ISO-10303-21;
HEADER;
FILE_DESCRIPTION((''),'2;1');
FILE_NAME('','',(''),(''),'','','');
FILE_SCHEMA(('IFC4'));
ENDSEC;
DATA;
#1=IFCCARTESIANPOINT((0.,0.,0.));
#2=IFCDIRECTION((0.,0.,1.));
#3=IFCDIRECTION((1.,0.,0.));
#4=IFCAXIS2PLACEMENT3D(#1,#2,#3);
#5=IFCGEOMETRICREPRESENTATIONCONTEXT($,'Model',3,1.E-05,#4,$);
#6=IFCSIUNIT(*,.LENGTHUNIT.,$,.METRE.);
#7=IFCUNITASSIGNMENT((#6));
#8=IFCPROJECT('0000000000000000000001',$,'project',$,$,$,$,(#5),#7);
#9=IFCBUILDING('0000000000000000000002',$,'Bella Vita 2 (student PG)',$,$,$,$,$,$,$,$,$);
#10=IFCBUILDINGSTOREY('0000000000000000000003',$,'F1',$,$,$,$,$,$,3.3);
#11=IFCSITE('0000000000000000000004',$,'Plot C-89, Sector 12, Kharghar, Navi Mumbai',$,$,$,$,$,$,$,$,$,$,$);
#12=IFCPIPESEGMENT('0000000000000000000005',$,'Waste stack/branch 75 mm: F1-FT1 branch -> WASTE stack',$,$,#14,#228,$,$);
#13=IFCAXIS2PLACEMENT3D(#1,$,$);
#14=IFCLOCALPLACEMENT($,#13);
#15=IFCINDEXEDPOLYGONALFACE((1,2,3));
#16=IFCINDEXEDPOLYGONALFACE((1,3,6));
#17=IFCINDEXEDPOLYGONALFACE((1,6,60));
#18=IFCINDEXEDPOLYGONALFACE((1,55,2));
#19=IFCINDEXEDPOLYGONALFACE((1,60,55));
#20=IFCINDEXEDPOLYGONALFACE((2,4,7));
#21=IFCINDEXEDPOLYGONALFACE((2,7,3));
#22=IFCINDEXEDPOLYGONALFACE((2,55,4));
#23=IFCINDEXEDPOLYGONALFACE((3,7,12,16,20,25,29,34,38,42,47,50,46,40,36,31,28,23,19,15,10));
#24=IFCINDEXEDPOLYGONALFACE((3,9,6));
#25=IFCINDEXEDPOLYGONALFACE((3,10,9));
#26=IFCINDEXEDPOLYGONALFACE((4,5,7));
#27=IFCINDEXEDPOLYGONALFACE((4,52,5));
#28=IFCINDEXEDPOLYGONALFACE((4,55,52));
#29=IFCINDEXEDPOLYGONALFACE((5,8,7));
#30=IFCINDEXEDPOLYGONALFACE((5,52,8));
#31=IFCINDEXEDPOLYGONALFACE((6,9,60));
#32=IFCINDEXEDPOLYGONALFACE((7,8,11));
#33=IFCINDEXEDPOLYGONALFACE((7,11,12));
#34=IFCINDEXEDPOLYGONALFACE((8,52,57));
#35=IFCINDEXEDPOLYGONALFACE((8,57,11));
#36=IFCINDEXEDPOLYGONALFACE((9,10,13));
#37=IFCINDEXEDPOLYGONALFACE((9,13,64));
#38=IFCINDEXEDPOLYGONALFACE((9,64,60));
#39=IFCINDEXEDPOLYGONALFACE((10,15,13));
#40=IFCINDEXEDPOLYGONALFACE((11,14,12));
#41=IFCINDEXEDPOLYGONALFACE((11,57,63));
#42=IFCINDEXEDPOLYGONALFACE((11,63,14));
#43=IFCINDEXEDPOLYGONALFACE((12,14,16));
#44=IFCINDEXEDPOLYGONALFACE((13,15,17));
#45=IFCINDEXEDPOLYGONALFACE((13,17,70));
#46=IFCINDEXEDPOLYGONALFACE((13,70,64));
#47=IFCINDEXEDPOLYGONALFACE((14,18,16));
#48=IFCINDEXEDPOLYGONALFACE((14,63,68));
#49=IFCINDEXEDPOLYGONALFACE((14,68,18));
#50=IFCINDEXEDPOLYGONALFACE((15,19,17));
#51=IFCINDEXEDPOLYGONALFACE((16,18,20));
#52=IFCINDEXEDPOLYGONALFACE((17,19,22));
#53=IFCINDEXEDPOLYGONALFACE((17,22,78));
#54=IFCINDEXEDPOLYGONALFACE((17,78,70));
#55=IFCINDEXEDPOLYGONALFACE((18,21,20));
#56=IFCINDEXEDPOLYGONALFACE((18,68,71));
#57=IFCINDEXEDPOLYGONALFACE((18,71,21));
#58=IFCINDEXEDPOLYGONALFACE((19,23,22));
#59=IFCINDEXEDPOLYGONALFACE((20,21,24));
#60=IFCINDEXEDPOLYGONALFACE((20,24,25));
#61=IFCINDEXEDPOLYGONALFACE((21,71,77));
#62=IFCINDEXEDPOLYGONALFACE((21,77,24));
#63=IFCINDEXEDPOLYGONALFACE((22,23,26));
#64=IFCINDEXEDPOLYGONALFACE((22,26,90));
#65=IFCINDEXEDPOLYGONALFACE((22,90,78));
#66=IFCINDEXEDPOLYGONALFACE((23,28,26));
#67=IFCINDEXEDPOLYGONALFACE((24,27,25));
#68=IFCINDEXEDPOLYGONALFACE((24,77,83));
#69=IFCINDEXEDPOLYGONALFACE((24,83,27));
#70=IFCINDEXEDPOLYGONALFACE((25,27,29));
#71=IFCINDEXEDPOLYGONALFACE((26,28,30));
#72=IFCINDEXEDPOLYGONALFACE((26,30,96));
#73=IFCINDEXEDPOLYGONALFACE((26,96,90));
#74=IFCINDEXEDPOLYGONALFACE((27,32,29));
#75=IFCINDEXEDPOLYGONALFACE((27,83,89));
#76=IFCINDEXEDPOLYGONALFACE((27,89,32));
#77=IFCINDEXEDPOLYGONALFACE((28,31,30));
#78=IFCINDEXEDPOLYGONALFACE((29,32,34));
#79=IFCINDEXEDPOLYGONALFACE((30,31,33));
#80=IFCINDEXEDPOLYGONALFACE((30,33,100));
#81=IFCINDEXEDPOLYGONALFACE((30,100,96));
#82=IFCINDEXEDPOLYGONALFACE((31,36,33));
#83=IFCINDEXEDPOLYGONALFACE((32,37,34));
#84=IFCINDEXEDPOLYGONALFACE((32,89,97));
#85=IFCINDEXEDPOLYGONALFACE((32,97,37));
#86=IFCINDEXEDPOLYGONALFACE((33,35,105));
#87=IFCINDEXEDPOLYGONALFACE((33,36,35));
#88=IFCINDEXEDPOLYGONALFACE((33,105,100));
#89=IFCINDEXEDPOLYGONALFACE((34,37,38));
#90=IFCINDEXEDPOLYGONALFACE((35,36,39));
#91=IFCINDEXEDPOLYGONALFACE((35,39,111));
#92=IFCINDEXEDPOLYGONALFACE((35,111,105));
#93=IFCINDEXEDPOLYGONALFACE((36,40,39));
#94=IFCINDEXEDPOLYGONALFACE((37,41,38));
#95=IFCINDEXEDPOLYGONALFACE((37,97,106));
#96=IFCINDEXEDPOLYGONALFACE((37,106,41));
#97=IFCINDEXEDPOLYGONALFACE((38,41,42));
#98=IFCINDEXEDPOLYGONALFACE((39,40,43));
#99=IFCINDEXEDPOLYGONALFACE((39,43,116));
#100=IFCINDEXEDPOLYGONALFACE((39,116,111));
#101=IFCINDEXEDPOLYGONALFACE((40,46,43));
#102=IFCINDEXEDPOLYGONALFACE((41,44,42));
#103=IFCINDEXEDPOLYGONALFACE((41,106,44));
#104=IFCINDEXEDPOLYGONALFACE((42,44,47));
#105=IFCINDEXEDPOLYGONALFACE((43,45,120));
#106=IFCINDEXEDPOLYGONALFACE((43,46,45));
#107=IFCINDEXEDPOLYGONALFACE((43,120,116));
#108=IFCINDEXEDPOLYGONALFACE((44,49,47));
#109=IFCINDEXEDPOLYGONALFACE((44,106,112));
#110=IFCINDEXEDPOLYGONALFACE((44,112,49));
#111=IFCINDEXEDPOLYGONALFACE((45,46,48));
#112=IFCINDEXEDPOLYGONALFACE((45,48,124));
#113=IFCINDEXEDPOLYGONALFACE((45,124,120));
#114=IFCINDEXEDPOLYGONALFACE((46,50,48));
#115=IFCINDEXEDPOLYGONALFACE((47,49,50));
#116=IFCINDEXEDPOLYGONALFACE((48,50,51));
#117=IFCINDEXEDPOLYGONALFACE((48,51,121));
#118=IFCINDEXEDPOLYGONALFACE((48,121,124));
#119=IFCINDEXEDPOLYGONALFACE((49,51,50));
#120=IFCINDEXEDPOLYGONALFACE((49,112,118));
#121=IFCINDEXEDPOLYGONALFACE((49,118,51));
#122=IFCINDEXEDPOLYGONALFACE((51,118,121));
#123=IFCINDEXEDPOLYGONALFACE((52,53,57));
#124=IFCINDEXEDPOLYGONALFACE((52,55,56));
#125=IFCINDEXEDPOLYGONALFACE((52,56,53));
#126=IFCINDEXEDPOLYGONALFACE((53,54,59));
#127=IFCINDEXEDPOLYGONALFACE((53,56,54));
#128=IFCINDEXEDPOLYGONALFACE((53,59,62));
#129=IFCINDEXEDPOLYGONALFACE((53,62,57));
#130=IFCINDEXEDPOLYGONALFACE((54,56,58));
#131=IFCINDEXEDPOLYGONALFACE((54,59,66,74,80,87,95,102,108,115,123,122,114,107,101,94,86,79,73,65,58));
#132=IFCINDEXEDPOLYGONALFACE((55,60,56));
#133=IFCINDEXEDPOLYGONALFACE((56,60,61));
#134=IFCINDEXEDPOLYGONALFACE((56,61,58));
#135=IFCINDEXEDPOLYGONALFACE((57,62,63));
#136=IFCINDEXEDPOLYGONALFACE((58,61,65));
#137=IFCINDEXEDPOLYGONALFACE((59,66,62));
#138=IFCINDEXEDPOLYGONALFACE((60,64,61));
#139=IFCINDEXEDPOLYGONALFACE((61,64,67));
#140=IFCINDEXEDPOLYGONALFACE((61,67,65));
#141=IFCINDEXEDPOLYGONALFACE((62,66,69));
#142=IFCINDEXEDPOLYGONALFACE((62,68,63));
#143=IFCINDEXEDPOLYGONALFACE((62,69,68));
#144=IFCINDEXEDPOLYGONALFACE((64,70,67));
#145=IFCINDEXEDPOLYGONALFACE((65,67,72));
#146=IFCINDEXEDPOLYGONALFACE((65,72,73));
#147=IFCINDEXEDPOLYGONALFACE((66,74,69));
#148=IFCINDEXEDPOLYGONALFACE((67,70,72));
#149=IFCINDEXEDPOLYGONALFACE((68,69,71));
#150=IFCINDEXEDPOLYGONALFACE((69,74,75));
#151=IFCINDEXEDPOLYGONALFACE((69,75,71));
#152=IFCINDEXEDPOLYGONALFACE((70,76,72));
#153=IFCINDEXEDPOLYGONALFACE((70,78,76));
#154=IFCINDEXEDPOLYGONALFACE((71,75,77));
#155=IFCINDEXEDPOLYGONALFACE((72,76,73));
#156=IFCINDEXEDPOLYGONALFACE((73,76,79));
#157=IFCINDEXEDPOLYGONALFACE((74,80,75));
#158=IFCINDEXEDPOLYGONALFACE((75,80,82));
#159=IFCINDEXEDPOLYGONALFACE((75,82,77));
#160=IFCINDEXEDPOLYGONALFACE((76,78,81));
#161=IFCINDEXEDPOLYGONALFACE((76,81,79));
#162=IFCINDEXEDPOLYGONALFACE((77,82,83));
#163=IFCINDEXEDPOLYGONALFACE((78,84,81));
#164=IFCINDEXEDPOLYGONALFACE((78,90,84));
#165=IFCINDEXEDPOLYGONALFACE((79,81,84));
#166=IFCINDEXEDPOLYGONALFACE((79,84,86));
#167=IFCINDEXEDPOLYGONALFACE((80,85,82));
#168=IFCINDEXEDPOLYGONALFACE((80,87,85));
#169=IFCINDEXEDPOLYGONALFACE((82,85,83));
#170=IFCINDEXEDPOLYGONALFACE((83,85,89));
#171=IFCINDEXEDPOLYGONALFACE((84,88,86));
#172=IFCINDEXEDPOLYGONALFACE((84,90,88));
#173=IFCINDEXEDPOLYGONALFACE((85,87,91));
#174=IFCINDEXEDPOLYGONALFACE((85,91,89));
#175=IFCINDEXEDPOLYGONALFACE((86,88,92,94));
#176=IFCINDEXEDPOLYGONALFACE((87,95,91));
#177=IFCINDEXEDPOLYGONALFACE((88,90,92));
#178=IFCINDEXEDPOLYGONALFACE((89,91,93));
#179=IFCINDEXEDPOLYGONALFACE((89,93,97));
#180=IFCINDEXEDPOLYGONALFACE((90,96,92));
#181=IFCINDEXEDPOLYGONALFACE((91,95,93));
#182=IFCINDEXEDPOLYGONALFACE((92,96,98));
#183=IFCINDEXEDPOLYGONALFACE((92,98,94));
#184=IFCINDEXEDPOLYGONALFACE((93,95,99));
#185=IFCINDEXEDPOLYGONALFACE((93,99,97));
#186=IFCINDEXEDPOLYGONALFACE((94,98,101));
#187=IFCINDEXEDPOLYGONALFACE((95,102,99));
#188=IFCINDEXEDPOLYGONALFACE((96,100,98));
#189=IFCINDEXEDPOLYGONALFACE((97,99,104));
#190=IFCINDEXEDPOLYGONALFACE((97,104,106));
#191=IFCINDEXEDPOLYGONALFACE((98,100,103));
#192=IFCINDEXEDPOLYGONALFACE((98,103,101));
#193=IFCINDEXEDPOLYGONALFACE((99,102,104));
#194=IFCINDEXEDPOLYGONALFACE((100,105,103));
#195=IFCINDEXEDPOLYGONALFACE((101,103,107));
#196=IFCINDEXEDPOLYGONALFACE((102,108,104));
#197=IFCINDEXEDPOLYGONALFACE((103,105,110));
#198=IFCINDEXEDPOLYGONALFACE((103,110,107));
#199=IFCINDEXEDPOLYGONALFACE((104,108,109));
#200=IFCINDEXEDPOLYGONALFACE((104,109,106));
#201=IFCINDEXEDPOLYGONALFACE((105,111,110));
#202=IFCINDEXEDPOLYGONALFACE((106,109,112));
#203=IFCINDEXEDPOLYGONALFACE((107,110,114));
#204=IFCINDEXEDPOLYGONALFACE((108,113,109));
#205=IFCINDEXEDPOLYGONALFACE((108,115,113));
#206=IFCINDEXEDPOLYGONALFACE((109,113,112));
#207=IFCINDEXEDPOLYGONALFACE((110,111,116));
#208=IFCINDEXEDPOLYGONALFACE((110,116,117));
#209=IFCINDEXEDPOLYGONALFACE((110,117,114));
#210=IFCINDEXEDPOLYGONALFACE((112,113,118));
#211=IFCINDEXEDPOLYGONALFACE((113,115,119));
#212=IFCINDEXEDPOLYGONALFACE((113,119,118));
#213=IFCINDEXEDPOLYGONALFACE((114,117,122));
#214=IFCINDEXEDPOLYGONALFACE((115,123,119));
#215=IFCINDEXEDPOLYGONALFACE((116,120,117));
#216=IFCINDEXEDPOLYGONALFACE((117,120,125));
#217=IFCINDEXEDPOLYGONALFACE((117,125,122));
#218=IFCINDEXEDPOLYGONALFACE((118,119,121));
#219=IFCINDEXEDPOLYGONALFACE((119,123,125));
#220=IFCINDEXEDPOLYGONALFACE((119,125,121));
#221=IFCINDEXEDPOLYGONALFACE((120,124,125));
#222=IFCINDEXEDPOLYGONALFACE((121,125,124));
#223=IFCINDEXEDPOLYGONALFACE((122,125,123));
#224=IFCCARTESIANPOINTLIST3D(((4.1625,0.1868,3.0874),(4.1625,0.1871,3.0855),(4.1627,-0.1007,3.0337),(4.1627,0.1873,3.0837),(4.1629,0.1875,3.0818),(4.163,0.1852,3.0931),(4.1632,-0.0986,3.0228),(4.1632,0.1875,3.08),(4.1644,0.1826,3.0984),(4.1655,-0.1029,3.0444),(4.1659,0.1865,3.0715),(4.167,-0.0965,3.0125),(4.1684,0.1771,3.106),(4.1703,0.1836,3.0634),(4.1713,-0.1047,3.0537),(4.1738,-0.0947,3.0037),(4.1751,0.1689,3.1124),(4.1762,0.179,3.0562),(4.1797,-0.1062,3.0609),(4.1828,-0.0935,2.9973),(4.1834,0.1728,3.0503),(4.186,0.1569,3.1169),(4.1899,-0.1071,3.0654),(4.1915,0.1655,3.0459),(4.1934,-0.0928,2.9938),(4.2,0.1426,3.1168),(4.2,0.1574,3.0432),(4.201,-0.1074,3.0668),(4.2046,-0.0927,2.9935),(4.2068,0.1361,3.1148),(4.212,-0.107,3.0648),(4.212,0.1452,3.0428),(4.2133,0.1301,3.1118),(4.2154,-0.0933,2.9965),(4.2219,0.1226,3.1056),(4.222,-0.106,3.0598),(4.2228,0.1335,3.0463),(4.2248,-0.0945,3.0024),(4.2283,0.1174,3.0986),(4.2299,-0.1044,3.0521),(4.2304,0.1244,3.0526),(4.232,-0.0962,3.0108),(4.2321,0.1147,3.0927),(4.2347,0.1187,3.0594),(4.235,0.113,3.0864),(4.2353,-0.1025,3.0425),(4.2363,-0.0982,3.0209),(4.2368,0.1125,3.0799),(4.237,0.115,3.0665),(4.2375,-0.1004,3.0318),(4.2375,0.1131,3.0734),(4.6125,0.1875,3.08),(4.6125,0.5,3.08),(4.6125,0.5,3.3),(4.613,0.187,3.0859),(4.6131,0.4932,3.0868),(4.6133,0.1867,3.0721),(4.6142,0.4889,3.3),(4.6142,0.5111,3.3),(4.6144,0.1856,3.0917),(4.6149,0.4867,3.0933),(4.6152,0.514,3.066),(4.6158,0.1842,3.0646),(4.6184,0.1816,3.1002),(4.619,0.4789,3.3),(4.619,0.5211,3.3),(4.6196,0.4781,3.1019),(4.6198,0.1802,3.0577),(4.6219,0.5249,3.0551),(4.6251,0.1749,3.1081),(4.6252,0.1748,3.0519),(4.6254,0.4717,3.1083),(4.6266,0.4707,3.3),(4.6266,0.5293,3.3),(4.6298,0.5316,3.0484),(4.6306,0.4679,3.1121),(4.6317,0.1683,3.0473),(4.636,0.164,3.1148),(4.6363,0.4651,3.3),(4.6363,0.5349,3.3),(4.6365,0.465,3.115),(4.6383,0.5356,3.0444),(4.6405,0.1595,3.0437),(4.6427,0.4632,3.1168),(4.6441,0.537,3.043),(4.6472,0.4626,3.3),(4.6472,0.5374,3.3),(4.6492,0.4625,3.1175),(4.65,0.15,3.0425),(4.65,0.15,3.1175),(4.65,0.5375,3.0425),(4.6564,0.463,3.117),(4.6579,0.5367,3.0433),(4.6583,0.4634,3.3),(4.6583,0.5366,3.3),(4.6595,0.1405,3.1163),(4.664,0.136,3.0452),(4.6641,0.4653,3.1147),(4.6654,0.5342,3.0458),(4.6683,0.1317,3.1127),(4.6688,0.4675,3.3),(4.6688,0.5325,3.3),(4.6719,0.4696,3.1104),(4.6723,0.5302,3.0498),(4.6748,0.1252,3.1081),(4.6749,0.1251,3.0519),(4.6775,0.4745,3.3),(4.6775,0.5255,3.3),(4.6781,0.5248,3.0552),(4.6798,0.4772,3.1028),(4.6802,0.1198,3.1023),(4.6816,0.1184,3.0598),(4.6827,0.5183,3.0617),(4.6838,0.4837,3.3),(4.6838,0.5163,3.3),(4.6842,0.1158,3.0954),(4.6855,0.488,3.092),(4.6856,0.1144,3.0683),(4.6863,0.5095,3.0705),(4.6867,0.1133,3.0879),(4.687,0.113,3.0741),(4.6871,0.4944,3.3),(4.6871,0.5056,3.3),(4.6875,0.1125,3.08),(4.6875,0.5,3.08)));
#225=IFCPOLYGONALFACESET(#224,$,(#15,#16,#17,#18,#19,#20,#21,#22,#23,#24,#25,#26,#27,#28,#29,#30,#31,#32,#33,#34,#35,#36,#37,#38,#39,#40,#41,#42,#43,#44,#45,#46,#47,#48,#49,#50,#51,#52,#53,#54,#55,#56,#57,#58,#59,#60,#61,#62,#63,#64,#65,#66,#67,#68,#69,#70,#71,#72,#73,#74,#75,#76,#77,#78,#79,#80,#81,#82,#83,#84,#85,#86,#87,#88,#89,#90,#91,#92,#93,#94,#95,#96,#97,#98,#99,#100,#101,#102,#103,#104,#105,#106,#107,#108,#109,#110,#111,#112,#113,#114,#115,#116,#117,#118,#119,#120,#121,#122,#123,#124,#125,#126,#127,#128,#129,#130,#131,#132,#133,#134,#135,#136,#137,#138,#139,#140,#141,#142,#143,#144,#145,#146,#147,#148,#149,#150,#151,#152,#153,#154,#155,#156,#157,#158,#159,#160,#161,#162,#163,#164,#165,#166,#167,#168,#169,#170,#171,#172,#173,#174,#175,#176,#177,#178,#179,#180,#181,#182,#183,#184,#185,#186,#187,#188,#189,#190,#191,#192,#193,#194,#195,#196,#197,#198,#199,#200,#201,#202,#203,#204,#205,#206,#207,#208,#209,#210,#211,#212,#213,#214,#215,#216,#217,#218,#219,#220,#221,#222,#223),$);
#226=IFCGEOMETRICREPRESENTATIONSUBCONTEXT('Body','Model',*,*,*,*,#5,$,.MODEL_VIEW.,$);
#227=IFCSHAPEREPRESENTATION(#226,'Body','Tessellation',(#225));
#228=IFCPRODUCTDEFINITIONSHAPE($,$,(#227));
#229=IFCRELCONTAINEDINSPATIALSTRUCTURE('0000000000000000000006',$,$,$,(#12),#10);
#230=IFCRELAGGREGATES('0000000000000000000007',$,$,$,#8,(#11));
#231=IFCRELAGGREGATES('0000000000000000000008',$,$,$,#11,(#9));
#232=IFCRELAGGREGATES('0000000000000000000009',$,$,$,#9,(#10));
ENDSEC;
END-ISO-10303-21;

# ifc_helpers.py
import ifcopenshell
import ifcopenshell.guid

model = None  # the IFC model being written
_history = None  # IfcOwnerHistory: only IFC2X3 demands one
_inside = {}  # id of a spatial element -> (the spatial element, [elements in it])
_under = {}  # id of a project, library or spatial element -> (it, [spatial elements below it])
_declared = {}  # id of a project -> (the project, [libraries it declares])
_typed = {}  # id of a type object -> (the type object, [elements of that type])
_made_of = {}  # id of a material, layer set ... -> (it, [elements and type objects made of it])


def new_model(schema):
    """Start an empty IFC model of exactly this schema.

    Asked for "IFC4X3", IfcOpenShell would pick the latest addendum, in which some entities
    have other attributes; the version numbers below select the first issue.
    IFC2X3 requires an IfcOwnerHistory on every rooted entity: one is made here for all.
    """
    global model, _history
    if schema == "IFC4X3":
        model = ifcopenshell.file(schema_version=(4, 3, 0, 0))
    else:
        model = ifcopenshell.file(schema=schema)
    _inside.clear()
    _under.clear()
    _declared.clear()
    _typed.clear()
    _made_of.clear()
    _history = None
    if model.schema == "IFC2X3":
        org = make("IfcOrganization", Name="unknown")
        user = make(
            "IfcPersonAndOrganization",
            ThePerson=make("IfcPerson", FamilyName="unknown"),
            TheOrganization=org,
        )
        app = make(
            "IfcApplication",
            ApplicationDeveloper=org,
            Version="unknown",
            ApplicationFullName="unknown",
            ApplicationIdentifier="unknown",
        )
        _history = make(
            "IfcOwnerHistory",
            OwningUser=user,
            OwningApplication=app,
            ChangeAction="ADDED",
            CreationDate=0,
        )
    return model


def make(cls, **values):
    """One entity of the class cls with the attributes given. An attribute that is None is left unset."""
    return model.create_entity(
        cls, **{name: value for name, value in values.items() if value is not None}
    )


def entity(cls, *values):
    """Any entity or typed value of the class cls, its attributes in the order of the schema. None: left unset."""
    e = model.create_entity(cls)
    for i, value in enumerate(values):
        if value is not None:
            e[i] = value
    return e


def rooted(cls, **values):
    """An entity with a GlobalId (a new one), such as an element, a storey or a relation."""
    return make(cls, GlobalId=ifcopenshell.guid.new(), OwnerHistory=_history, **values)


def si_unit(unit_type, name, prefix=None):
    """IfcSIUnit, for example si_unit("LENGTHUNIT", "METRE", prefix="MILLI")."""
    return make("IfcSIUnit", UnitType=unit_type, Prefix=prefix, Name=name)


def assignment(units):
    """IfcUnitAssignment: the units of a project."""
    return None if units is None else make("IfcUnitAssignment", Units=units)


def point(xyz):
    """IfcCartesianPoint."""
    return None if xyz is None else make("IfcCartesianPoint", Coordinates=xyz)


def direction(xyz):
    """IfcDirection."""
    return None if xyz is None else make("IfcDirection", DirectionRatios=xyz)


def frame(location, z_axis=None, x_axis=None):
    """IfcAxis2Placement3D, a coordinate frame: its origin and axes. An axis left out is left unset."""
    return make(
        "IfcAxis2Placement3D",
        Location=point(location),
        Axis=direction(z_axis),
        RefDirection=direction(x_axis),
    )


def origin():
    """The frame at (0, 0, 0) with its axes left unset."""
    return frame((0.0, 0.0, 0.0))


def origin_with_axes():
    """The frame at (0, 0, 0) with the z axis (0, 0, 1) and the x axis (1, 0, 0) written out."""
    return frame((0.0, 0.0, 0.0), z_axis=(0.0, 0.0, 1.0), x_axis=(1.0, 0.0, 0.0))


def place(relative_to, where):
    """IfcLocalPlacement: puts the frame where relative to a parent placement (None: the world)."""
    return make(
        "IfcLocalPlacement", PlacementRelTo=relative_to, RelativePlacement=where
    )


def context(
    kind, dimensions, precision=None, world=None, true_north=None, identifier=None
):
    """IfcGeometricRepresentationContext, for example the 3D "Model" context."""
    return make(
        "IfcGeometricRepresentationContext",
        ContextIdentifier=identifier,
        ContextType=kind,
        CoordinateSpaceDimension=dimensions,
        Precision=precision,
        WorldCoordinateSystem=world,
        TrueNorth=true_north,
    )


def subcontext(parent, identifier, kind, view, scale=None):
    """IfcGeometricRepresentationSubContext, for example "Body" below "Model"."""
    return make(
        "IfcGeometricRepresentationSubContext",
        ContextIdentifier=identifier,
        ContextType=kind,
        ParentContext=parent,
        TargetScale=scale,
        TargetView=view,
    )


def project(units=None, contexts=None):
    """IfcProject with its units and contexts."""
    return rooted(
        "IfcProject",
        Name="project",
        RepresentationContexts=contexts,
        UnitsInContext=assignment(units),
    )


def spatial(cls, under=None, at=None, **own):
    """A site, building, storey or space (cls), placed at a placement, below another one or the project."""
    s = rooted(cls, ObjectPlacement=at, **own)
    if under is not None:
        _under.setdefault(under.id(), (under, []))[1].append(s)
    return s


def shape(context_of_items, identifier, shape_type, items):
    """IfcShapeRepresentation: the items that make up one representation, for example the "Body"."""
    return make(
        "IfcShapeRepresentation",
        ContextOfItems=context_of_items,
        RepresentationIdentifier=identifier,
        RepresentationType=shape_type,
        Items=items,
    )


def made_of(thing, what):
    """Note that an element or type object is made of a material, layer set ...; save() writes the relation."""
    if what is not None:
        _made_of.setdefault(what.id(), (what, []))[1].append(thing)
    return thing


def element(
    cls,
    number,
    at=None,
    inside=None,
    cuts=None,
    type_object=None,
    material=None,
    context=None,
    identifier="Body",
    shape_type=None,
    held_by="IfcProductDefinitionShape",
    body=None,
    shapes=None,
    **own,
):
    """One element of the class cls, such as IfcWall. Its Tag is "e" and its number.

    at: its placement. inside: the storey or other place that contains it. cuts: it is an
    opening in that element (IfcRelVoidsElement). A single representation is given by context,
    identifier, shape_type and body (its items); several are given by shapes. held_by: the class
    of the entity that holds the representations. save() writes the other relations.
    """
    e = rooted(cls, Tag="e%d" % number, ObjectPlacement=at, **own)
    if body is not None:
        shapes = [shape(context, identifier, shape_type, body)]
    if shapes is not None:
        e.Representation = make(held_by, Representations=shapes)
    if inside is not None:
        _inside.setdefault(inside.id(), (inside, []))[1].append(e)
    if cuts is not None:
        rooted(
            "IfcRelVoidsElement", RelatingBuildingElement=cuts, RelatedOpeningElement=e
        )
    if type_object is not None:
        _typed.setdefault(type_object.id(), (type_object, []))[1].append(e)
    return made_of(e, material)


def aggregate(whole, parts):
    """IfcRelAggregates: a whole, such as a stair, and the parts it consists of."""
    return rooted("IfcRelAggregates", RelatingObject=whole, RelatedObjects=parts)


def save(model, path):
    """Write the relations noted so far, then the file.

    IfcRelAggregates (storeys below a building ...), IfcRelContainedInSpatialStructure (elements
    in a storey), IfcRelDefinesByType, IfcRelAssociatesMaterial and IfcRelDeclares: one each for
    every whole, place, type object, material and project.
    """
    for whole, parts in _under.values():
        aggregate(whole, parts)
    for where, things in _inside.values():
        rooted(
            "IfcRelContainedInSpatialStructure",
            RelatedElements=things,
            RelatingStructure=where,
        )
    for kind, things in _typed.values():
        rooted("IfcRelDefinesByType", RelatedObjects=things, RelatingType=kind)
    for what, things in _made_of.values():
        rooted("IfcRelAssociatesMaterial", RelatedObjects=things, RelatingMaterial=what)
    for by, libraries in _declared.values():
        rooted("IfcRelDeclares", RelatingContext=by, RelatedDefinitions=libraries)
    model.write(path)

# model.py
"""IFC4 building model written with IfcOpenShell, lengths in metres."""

from ifc_helpers import new_model, entity, si_unit, origin, origin_with_axes, place, context, subcontext, project, spatial, element, save


model = new_model("IFC4")

# Units and contexts
model_context = context("Model", 3, precision=1e-05, world=origin_with_axes())
body_context = subcontext(model_context, "Body", "Model", "MODEL_VIEW")
ifc_project = project(units=[si_unit("LENGTHUNIT", "METRE")], contexts=[model_context])

# Site, building, storey
site = spatial("IfcSite", under=ifc_project, Name="Plot C-89, Sector 12, Kharghar, Navi Mumbai")
building = spatial("IfcBuilding", under=site, Name="Bella Vita 2 (student PG)")
storey = spatial("IfcBuildingStorey", under=building, Name="F1", Elevation=3.3)

# Pipe segment
pipe_segment_1_placement = place(None, origin())
element("IfcPipeSegment", 1, at=pipe_segment_1_placement, inside=storey, Name="Waste stack/branch 75 mm: F1-FT1 branch -> WASTE stack", context=body_context, shape_type="AdvancedSweptSolid", body=[
    entity("IfcSweptDiskSolid", entity("IfcPolyline", [entity("IfcCartesianPoint", [4.65, 0.5, 3.3]), entity("IfcCartesianPoint", [4.65, 0.5, 3.08]), entity("IfcCartesianPoint", [4.65, 0.15, 3.08]), entity("IfcCartesianPoint", [4.2, 0.15, 3.08]), entity("IfcCartesianPoint", [4.2, -0.1, 3.03])]), 0.0375),
])

save(model, "model.ifc")
